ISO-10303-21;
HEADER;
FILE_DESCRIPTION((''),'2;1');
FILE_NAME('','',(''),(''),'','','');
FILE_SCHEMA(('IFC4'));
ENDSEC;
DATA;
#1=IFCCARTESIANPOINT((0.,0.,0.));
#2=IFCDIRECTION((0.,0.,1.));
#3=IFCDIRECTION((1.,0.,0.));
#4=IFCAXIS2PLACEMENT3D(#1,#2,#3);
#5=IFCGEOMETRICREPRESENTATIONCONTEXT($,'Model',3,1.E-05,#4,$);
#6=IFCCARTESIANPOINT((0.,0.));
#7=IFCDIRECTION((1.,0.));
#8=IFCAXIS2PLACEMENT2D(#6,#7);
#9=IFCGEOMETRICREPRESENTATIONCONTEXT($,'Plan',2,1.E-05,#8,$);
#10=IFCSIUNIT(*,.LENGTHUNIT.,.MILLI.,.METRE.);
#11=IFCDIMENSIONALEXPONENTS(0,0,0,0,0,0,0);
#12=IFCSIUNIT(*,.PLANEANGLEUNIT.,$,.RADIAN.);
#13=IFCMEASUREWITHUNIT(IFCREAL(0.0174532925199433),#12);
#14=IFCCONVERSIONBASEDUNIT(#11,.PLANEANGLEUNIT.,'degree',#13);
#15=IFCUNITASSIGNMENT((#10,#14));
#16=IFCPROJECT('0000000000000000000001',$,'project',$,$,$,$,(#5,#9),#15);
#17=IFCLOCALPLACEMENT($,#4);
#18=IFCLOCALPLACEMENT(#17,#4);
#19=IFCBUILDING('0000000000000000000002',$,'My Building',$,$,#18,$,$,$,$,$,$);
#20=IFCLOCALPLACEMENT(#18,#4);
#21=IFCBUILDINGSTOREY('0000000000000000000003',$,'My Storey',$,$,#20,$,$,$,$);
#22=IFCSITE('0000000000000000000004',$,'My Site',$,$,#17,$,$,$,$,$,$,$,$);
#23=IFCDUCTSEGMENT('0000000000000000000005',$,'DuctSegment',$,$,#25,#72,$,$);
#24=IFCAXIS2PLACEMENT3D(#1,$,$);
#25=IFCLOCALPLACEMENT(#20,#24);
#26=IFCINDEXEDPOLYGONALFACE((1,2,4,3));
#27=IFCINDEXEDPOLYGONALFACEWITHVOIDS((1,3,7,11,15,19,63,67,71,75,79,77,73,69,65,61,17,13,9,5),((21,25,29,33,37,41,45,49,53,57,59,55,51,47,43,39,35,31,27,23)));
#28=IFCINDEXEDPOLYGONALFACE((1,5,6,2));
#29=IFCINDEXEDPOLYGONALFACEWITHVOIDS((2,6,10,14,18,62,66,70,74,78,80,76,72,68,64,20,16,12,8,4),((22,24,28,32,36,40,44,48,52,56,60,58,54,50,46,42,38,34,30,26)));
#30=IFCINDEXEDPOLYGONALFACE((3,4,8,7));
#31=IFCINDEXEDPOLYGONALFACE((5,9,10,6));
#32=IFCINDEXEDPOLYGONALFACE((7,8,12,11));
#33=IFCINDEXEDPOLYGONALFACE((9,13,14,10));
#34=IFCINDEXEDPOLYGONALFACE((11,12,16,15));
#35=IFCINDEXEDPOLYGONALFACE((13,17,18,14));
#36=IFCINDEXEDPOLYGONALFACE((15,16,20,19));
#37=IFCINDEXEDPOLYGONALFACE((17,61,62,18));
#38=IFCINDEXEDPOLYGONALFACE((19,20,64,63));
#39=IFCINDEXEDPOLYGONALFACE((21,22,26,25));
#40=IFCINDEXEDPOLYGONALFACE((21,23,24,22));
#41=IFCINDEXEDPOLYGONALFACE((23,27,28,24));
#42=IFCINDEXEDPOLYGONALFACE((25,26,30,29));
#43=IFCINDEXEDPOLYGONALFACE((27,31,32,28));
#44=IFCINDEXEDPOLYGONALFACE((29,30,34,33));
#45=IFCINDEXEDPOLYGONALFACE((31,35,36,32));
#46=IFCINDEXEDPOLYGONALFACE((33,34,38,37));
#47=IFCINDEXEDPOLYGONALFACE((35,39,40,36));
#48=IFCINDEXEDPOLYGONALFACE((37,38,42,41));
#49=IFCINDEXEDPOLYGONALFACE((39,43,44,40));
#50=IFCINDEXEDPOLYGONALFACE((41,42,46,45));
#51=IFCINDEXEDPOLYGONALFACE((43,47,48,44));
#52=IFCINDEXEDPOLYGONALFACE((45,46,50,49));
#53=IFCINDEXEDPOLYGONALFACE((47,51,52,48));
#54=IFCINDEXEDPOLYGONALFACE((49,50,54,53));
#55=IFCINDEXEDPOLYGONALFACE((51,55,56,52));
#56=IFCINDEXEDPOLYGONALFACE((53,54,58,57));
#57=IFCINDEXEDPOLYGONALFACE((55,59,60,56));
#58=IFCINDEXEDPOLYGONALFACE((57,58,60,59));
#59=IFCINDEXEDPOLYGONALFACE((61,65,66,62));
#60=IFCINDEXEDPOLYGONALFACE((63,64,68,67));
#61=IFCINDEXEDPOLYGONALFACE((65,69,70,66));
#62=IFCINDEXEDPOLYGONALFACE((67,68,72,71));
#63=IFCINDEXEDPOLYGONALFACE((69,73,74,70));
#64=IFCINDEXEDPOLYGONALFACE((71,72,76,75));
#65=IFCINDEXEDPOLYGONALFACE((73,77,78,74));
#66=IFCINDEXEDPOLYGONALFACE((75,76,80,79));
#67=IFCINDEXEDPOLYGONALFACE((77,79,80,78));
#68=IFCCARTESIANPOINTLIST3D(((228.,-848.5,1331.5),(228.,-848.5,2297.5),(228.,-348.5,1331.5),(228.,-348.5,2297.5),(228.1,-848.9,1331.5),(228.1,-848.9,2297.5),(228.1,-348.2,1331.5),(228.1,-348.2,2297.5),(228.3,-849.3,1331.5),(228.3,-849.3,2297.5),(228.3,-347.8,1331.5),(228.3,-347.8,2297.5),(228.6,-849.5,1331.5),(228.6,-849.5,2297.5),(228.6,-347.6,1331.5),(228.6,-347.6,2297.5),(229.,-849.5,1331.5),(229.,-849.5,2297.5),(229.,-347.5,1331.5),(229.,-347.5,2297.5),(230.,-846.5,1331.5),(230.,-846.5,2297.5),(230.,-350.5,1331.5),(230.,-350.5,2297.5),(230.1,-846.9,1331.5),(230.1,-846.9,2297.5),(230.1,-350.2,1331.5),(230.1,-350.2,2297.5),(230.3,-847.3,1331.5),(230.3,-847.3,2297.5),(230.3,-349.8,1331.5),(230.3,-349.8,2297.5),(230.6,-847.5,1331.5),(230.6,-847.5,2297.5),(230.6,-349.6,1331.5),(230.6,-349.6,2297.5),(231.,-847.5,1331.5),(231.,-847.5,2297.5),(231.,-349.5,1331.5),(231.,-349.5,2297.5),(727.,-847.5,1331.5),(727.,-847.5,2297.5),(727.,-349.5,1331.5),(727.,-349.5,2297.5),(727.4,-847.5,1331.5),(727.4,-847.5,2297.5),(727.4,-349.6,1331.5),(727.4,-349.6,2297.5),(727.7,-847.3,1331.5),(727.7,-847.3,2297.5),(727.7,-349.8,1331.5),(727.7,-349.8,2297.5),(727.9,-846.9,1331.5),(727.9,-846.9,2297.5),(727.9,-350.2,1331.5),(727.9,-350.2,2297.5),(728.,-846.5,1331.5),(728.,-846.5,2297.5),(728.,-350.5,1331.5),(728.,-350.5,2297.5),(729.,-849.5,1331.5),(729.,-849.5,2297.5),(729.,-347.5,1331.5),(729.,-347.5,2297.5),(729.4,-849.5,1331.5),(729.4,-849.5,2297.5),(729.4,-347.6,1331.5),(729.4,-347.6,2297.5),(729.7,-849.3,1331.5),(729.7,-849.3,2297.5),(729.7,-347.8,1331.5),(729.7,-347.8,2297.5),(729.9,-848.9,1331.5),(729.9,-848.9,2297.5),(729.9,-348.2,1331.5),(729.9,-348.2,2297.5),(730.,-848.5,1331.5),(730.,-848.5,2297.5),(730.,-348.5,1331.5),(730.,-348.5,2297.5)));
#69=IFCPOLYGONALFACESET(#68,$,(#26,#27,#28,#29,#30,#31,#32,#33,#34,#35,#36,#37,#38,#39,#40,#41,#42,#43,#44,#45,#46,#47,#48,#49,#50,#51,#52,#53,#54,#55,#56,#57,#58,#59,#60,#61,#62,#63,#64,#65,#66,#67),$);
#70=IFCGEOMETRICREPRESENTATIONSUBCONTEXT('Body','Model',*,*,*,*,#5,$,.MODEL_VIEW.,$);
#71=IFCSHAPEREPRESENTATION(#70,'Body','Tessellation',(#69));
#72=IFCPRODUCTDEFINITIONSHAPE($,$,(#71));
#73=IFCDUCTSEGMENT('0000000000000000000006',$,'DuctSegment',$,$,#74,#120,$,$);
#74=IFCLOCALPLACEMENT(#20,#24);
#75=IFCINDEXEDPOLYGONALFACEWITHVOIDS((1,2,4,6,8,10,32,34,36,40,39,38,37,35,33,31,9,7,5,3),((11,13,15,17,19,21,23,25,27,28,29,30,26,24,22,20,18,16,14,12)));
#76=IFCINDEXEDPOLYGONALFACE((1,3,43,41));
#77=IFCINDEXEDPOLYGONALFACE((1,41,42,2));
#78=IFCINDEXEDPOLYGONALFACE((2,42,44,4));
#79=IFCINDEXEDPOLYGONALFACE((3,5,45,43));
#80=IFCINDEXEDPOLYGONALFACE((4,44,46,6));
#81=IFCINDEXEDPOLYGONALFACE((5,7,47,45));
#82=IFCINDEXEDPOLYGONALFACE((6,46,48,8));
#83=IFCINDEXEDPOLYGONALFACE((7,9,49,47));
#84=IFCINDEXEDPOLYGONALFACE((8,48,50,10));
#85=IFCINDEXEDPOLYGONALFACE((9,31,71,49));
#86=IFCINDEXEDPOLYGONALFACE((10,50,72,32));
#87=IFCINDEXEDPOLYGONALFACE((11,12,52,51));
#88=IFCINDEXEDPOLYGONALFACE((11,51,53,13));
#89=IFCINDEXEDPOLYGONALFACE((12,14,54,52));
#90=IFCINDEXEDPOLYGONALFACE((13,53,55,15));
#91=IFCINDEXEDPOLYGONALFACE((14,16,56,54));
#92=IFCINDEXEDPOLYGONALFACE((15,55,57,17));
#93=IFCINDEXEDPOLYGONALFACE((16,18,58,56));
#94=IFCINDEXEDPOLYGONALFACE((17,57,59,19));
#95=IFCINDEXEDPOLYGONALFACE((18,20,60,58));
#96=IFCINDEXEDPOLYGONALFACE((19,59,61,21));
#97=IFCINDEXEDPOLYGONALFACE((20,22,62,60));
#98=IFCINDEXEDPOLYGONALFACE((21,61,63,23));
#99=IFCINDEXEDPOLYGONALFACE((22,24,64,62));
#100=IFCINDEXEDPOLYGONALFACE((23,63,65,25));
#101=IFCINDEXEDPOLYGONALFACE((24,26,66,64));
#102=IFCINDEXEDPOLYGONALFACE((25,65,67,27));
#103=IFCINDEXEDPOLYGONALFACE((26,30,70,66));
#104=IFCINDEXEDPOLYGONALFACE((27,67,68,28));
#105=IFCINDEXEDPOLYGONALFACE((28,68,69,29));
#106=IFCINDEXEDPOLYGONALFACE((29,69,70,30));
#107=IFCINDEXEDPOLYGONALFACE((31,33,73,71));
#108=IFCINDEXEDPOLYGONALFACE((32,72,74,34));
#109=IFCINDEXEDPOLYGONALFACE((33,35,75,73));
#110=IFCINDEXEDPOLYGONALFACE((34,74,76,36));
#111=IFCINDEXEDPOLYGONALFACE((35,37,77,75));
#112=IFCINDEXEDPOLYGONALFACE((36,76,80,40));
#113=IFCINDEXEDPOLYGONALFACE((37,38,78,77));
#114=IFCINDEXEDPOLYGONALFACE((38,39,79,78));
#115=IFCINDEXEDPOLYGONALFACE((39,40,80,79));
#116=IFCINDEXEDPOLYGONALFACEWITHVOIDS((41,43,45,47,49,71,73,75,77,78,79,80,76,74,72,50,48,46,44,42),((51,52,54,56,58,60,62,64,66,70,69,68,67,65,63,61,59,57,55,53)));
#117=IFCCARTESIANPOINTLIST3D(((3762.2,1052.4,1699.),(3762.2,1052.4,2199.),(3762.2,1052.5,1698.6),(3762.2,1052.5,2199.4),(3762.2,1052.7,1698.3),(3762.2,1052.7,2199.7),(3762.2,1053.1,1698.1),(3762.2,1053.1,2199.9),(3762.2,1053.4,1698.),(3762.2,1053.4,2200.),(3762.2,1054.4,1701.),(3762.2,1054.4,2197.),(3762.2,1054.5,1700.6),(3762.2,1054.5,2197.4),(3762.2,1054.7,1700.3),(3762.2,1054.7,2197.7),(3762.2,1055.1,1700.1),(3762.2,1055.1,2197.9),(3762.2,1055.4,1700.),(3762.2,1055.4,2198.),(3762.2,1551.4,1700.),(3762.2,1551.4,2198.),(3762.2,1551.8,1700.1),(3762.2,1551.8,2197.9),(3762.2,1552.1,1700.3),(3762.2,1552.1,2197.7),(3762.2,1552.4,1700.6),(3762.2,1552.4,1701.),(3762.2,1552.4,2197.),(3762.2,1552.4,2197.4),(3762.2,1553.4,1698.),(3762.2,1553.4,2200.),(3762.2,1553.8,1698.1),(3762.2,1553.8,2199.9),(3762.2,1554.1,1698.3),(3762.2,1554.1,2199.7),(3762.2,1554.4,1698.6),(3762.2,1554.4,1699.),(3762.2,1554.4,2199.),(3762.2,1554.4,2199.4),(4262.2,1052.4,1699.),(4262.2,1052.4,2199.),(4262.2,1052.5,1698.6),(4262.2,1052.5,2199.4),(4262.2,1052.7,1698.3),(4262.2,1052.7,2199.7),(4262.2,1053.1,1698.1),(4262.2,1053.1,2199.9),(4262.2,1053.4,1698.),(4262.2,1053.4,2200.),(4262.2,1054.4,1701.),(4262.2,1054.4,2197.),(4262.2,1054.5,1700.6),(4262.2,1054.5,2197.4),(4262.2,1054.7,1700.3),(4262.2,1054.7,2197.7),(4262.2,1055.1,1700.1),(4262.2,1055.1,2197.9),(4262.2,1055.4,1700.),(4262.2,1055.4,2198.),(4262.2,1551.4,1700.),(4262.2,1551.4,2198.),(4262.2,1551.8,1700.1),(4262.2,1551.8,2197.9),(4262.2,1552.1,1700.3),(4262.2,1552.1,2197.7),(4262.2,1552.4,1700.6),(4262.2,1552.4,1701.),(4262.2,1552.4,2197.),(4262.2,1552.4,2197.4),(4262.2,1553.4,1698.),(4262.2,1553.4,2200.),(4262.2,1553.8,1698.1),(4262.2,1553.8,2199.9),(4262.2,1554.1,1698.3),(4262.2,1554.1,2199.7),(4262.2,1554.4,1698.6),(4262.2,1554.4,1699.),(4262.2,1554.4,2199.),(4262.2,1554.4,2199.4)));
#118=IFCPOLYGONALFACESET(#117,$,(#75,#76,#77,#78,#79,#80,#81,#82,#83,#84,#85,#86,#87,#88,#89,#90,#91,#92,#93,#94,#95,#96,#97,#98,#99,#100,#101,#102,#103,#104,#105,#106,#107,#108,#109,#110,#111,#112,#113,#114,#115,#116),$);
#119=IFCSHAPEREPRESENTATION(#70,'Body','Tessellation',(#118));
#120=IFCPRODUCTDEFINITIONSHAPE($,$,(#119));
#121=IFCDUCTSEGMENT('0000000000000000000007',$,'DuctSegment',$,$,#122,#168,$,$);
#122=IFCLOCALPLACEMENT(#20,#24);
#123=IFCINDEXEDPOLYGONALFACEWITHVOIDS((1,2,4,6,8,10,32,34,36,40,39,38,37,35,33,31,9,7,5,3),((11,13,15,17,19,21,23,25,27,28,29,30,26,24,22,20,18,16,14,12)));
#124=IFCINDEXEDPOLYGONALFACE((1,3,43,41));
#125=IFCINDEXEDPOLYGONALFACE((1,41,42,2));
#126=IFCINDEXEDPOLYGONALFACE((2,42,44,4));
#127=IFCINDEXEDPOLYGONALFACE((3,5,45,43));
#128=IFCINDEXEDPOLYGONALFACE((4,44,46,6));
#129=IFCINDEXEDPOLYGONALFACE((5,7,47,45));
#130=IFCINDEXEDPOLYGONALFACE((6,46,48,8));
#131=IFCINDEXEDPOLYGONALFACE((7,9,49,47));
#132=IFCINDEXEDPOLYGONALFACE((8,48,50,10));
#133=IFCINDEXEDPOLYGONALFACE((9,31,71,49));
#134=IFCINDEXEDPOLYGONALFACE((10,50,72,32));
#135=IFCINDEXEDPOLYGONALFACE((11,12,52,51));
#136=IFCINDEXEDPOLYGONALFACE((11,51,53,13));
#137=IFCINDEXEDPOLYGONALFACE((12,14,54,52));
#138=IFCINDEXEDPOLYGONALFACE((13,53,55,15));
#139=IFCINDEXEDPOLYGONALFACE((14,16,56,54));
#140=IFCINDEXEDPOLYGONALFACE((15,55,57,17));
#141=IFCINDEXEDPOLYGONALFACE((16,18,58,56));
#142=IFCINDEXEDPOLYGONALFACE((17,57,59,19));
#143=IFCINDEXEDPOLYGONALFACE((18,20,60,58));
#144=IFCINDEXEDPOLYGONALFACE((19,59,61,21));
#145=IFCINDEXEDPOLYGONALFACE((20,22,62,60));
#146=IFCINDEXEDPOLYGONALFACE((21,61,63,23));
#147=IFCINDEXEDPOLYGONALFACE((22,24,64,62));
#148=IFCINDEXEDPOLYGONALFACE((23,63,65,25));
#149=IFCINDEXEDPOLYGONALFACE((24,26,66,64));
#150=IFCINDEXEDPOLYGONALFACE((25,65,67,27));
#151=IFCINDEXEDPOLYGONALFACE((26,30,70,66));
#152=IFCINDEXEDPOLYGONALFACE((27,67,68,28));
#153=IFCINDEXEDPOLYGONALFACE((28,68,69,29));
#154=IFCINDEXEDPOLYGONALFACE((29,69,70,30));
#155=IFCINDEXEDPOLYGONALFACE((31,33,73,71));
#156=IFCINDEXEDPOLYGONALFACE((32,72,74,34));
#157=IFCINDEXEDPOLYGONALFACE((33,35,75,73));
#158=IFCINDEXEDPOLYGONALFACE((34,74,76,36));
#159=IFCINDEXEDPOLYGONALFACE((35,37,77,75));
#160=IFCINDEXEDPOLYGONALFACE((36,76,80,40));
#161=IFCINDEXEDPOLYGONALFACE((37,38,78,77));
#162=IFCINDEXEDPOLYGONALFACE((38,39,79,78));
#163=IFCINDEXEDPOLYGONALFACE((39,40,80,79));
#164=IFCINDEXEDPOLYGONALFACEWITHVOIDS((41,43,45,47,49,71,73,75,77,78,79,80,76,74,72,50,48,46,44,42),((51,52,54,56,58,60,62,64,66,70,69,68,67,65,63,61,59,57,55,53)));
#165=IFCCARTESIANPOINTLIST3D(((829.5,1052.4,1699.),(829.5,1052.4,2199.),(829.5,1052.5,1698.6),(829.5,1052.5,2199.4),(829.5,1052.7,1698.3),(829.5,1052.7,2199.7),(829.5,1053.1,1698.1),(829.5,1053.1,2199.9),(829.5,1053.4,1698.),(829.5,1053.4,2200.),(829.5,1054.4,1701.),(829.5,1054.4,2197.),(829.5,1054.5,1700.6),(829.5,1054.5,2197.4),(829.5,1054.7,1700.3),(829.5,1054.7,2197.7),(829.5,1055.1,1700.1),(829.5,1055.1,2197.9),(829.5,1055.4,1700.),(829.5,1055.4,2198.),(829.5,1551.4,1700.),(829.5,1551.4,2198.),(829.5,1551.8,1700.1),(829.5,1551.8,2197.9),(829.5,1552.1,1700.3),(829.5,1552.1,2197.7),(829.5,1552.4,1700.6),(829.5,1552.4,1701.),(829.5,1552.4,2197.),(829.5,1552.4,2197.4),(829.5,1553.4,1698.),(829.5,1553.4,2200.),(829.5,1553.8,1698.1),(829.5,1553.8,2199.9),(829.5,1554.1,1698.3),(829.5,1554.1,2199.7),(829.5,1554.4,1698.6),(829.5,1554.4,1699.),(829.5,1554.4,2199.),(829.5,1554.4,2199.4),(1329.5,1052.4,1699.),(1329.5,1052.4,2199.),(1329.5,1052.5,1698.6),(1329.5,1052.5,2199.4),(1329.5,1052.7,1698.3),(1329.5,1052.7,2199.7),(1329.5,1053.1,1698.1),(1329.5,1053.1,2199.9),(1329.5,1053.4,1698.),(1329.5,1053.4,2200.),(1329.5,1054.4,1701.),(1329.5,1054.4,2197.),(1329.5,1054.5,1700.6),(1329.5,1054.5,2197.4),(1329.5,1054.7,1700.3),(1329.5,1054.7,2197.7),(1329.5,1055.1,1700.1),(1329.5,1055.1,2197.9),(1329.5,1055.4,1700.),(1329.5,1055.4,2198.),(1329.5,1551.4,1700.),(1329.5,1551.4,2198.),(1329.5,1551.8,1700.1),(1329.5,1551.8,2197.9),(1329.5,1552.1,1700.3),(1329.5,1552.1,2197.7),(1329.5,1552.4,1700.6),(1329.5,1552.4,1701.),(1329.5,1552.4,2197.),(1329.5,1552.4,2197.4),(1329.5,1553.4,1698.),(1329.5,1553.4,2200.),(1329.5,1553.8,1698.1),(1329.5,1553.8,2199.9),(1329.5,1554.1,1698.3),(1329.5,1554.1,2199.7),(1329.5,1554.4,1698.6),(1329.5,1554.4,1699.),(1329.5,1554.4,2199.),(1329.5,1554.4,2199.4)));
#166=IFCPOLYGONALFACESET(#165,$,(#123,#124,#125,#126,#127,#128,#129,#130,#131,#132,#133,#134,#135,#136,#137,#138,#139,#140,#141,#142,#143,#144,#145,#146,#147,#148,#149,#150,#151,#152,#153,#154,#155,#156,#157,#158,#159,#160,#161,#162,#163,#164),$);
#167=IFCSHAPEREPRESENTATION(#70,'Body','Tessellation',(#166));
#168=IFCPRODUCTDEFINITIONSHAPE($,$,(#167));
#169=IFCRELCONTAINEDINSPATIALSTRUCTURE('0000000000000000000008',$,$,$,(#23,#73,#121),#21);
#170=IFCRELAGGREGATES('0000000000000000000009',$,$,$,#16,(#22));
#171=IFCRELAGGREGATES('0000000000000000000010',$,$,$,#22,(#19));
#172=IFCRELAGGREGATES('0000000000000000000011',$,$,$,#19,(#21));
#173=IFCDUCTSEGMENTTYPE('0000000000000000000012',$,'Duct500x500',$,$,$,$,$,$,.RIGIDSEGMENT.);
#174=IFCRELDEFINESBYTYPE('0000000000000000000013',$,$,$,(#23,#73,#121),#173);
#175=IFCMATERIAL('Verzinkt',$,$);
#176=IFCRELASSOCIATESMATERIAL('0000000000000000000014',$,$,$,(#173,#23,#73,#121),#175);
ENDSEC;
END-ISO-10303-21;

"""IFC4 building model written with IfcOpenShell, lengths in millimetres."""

from ifc_helpers import new_model, entity, si_unit, converted_unit, frame, origin_with_axes, origin_2d_with_axis, place, context, subcontext, project, spatial, hollow_rectangle, extrude, material, material_profile, profile_set, profile_usage, type_object, element, save


model = new_model("IFC4")

# Units and contexts
model_context = context("Model", 3, precision=1e-05, world=origin_with_axes())
plan_context = context("Plan", 2, precision=1e-05, world=origin_2d_with_axis())
body_context = subcontext(model_context, "Body", "Model", "MODEL_VIEW")
ifc_project = project(units=[si_unit("LENGTHUNIT", "METRE", prefix="MILLI"), converted_unit("PLANEANGLEUNIT", "degree", entity("IfcReal", 0.0174532925199433), si_unit("PLANEANGLEUNIT", "RADIAN"), dimensions=[0, 0, 0, 0, 0, 0, 0])], contexts=[model_context, plan_context])

# Site, building, storey
site_placement = place(None, origin_with_axes())
site = spatial("IfcSite", under=ifc_project, at=site_placement, Name="My Site")
building_placement = place(site_placement, origin_with_axes())
building = spatial("IfcBuilding", under=site, at=building_placement, Name="My Building")
storey_placement = place(building_placement, origin_with_axes())
storey = spatial("IfcBuildingStorey", under=building, at=storey_placement, Name="My Storey")

# Shared definitions
ifc_material = material(Name="Verzinkt")

# Duct segments
ifc_material_profile_1 = material_profile(ifc_material, hollow_rectangle(XDim=502.0, YDim=502.0, WallThickness=2.0, InnerFilletRadius=1.0, OuterFilletRadius=1.0))
ifc_profile_set_1 = profile_set([ifc_material_profile_1])
duct_segment_type_1 = type_object("IfcDuctSegmentType", Name="Duct500x500", PredefinedType="RIGIDSEGMENT", material=ifc_profile_set_1)
ifc_profile_usage_1 = profile_usage(ifc_profile_set_1, cardinal=5)
duct_segment_1_placement = place(storey_placement, frame((479.0, -598.5, 2297.5), z_axis=(0.0, 0.0, -1.0), x_axis=(1.0, 0.0, 0.0)))
element("IfcDuctSegment", 1, at=duct_segment_1_placement, inside=storey, type_object=duct_segment_type_1, material=ifc_profile_usage_1, Name="DuctSegment", context=body_context, shape_type="SweptSolid", body=[
    extrude(hollow_rectangle(XDim=502.0, YDim=502.0, WallThickness=2.0, InnerFilletRadius=1.0, OuterFilletRadius=1.0), origin_with_axes(), (0.0, 0.0, 1.0), 966.0),
])
ifc_profile_usage_2 = profile_usage(ifc_profile_set_1, cardinal=5)
duct_segment_2_placement = place(storey_placement, frame((4262.2, 1303.4, 1949.0), z_axis=(-1.0, 0.0, 0.0), x_axis=(0.0, -1.0, 0.0)))
element("IfcDuctSegment", 2, at=duct_segment_2_placement, inside=storey, type_object=duct_segment_type_1, material=ifc_profile_usage_2, Name="DuctSegment", context=body_context, shape_type="SweptSolid", body=[
    extrude(hollow_rectangle(XDim=502.0, YDim=502.0, WallThickness=2.0, InnerFilletRadius=1.0, OuterFilletRadius=1.0), origin_with_axes(), (0.0, 0.0, 1.0), 500.0),
])
ifc_profile_usage_3 = profile_usage(ifc_profile_set_1, cardinal=5)
duct_segment_3_placement = place(storey_placement, frame((1329.5, 1303.4, 1949.0), z_axis=(-1.0, 0.0, 0.0), x_axis=(0.0, -1.0, 0.0)))
element("IfcDuctSegment", 3, at=duct_segment_3_placement, inside=storey, type_object=duct_segment_type_1, material=ifc_profile_usage_3, Name="DuctSegment", context=body_context, shape_type="SweptSolid", body=[
    extrude(hollow_rectangle(XDim=502.0, YDim=502.0, WallThickness=2.0, InnerFilletRadius=1.0, OuterFilletRadius=1.0), origin_with_axes(), (0.0, 0.0, 1.0), 500.0),
])

save(model, "model.ifc")
